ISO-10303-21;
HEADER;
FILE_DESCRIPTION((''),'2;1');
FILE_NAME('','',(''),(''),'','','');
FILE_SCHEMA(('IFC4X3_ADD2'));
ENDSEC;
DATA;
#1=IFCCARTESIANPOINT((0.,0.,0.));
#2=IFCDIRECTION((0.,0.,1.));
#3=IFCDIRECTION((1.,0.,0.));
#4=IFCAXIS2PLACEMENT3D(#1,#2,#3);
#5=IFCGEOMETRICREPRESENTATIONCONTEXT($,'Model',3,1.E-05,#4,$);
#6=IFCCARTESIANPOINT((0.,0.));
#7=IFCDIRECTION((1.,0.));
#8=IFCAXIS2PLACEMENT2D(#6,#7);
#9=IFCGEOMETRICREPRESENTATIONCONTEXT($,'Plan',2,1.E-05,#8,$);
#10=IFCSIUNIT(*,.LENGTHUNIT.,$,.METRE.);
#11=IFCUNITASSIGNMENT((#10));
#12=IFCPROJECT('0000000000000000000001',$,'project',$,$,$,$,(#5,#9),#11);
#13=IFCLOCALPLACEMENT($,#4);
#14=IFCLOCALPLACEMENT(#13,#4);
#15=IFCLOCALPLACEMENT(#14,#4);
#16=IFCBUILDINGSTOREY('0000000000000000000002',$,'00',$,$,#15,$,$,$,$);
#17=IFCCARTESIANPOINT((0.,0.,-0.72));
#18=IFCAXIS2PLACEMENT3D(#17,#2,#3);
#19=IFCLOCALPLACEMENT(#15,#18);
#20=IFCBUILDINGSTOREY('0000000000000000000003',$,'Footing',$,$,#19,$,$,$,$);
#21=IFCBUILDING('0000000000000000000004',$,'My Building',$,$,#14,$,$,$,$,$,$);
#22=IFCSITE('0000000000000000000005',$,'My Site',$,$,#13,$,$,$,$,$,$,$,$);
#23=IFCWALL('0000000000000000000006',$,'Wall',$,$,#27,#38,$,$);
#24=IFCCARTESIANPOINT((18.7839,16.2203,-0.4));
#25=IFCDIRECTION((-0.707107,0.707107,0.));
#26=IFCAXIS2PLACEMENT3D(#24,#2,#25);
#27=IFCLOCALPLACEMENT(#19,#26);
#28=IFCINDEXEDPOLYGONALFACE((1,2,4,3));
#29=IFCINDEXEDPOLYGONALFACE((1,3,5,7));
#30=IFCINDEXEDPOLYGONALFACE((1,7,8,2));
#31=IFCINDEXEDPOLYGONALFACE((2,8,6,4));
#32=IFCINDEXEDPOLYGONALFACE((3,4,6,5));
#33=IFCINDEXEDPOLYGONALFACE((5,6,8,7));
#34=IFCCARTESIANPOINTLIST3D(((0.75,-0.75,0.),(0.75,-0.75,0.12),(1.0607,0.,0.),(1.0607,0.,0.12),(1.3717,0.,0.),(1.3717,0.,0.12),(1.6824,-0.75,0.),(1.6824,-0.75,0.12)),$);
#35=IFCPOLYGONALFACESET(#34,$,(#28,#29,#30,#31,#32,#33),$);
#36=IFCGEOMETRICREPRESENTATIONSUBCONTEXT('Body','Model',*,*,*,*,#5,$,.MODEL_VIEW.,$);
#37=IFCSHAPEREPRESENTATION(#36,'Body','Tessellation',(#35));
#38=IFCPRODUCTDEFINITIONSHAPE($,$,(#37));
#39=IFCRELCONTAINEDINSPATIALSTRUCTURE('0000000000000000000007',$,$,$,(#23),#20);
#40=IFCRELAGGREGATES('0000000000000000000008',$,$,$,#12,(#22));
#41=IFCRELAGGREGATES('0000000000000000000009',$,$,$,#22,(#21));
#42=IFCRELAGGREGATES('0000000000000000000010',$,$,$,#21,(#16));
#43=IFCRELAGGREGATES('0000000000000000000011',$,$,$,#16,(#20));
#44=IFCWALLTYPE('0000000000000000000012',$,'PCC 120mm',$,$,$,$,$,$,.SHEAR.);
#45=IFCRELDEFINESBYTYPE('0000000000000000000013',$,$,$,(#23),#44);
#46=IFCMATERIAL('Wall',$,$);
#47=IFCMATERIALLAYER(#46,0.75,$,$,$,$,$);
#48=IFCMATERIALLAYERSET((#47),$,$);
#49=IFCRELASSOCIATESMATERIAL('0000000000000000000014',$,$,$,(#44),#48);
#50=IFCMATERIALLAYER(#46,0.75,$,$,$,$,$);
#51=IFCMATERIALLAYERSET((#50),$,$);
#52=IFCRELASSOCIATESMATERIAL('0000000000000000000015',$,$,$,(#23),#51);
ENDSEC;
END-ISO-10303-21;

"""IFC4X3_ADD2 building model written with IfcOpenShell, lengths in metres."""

from ifc_helpers import new_model, si_unit, frame, origin_with_axes, origin_2d_with_axis, place, context, subcontext, project, spatial, line, indexed_curve, outline, extrude, material, layer, layer_set, layer_usage, type_object, element, save


model = new_model("IFC4X3_ADD2")

# Units and contexts
model_context = context("Model", 3, precision=1e-05, world=origin_with_axes())
plan_context = context("Plan", 2, precision=1e-05, world=origin_2d_with_axis())
body_context = subcontext(model_context, "Body", "Model", "MODEL_VIEW")
ifc_project = project(units=[si_unit("LENGTHUNIT", "METRE")], contexts=[model_context, plan_context])

# Site, building, storeys
site_placement = place(None, origin_with_axes())
site = spatial("IfcSite", under=ifc_project, at=site_placement, Name="My Site")
building_placement = place(site_placement, origin_with_axes())
building = spatial("IfcBuilding", under=site, at=building_placement, Name="My Building")
storey_1_placement = place(building_placement, origin_with_axes())
storey_1 = spatial("IfcBuildingStorey", under=building, at=storey_1_placement, Name="00")
storey_2_placement = place(storey_1_placement, frame((0.0, 0.0, -0.72), z_axis=(0.0, 0.0, 1.0), x_axis=(1.0, 0.0, 0.0)))
storey_2 = spatial("IfcBuildingStorey", under=storey_1, at=storey_2_placement, Name="Footing")

# Wall
ifc_material_1 = material(Name="Wall")
ifc_layer_1 = layer(ifc_material_1, 0.75)
ifc_layer_set_1 = layer_set([ifc_layer_1])
wall_type_1 = type_object("IfcWallType", Name="PCC 120mm", PredefinedType="SHEAR", material=ifc_layer_set_1)
ifc_layer_2 = layer(ifc_material_1, 0.75)
ifc_layer_set_2 = layer_set([ifc_layer_2])
ifc_layer_usage_1 = layer_usage(ifc_layer_set_2, "AXIS2", "NEGATIVE", 0.0)
wall_1_placement = place(storey_2_placement, frame((18.7839, 16.2203, -0.4), z_axis=(0.0, 0.0, 1.0), x_axis=(-0.707107, 0.707107, 0.0)))
element("IfcWall", 1, at=wall_1_placement, inside=storey_2, type_object=wall_type_1, material=ifc_layer_usage_1, Name="Wall", context=body_context, shape_type="SweptSolid", body=[
    extrude(outline(indexed_curve([(0.75, -0.75), (1.0607, 0.0), (1.3717, 0.0), (1.6824, -0.75)], segments=[line(1, 2, 3, 4, 1)])), origin_with_axes(), (0.0, 0.0, 1.0), 0.12),
])

save(model, "model.ifc")
